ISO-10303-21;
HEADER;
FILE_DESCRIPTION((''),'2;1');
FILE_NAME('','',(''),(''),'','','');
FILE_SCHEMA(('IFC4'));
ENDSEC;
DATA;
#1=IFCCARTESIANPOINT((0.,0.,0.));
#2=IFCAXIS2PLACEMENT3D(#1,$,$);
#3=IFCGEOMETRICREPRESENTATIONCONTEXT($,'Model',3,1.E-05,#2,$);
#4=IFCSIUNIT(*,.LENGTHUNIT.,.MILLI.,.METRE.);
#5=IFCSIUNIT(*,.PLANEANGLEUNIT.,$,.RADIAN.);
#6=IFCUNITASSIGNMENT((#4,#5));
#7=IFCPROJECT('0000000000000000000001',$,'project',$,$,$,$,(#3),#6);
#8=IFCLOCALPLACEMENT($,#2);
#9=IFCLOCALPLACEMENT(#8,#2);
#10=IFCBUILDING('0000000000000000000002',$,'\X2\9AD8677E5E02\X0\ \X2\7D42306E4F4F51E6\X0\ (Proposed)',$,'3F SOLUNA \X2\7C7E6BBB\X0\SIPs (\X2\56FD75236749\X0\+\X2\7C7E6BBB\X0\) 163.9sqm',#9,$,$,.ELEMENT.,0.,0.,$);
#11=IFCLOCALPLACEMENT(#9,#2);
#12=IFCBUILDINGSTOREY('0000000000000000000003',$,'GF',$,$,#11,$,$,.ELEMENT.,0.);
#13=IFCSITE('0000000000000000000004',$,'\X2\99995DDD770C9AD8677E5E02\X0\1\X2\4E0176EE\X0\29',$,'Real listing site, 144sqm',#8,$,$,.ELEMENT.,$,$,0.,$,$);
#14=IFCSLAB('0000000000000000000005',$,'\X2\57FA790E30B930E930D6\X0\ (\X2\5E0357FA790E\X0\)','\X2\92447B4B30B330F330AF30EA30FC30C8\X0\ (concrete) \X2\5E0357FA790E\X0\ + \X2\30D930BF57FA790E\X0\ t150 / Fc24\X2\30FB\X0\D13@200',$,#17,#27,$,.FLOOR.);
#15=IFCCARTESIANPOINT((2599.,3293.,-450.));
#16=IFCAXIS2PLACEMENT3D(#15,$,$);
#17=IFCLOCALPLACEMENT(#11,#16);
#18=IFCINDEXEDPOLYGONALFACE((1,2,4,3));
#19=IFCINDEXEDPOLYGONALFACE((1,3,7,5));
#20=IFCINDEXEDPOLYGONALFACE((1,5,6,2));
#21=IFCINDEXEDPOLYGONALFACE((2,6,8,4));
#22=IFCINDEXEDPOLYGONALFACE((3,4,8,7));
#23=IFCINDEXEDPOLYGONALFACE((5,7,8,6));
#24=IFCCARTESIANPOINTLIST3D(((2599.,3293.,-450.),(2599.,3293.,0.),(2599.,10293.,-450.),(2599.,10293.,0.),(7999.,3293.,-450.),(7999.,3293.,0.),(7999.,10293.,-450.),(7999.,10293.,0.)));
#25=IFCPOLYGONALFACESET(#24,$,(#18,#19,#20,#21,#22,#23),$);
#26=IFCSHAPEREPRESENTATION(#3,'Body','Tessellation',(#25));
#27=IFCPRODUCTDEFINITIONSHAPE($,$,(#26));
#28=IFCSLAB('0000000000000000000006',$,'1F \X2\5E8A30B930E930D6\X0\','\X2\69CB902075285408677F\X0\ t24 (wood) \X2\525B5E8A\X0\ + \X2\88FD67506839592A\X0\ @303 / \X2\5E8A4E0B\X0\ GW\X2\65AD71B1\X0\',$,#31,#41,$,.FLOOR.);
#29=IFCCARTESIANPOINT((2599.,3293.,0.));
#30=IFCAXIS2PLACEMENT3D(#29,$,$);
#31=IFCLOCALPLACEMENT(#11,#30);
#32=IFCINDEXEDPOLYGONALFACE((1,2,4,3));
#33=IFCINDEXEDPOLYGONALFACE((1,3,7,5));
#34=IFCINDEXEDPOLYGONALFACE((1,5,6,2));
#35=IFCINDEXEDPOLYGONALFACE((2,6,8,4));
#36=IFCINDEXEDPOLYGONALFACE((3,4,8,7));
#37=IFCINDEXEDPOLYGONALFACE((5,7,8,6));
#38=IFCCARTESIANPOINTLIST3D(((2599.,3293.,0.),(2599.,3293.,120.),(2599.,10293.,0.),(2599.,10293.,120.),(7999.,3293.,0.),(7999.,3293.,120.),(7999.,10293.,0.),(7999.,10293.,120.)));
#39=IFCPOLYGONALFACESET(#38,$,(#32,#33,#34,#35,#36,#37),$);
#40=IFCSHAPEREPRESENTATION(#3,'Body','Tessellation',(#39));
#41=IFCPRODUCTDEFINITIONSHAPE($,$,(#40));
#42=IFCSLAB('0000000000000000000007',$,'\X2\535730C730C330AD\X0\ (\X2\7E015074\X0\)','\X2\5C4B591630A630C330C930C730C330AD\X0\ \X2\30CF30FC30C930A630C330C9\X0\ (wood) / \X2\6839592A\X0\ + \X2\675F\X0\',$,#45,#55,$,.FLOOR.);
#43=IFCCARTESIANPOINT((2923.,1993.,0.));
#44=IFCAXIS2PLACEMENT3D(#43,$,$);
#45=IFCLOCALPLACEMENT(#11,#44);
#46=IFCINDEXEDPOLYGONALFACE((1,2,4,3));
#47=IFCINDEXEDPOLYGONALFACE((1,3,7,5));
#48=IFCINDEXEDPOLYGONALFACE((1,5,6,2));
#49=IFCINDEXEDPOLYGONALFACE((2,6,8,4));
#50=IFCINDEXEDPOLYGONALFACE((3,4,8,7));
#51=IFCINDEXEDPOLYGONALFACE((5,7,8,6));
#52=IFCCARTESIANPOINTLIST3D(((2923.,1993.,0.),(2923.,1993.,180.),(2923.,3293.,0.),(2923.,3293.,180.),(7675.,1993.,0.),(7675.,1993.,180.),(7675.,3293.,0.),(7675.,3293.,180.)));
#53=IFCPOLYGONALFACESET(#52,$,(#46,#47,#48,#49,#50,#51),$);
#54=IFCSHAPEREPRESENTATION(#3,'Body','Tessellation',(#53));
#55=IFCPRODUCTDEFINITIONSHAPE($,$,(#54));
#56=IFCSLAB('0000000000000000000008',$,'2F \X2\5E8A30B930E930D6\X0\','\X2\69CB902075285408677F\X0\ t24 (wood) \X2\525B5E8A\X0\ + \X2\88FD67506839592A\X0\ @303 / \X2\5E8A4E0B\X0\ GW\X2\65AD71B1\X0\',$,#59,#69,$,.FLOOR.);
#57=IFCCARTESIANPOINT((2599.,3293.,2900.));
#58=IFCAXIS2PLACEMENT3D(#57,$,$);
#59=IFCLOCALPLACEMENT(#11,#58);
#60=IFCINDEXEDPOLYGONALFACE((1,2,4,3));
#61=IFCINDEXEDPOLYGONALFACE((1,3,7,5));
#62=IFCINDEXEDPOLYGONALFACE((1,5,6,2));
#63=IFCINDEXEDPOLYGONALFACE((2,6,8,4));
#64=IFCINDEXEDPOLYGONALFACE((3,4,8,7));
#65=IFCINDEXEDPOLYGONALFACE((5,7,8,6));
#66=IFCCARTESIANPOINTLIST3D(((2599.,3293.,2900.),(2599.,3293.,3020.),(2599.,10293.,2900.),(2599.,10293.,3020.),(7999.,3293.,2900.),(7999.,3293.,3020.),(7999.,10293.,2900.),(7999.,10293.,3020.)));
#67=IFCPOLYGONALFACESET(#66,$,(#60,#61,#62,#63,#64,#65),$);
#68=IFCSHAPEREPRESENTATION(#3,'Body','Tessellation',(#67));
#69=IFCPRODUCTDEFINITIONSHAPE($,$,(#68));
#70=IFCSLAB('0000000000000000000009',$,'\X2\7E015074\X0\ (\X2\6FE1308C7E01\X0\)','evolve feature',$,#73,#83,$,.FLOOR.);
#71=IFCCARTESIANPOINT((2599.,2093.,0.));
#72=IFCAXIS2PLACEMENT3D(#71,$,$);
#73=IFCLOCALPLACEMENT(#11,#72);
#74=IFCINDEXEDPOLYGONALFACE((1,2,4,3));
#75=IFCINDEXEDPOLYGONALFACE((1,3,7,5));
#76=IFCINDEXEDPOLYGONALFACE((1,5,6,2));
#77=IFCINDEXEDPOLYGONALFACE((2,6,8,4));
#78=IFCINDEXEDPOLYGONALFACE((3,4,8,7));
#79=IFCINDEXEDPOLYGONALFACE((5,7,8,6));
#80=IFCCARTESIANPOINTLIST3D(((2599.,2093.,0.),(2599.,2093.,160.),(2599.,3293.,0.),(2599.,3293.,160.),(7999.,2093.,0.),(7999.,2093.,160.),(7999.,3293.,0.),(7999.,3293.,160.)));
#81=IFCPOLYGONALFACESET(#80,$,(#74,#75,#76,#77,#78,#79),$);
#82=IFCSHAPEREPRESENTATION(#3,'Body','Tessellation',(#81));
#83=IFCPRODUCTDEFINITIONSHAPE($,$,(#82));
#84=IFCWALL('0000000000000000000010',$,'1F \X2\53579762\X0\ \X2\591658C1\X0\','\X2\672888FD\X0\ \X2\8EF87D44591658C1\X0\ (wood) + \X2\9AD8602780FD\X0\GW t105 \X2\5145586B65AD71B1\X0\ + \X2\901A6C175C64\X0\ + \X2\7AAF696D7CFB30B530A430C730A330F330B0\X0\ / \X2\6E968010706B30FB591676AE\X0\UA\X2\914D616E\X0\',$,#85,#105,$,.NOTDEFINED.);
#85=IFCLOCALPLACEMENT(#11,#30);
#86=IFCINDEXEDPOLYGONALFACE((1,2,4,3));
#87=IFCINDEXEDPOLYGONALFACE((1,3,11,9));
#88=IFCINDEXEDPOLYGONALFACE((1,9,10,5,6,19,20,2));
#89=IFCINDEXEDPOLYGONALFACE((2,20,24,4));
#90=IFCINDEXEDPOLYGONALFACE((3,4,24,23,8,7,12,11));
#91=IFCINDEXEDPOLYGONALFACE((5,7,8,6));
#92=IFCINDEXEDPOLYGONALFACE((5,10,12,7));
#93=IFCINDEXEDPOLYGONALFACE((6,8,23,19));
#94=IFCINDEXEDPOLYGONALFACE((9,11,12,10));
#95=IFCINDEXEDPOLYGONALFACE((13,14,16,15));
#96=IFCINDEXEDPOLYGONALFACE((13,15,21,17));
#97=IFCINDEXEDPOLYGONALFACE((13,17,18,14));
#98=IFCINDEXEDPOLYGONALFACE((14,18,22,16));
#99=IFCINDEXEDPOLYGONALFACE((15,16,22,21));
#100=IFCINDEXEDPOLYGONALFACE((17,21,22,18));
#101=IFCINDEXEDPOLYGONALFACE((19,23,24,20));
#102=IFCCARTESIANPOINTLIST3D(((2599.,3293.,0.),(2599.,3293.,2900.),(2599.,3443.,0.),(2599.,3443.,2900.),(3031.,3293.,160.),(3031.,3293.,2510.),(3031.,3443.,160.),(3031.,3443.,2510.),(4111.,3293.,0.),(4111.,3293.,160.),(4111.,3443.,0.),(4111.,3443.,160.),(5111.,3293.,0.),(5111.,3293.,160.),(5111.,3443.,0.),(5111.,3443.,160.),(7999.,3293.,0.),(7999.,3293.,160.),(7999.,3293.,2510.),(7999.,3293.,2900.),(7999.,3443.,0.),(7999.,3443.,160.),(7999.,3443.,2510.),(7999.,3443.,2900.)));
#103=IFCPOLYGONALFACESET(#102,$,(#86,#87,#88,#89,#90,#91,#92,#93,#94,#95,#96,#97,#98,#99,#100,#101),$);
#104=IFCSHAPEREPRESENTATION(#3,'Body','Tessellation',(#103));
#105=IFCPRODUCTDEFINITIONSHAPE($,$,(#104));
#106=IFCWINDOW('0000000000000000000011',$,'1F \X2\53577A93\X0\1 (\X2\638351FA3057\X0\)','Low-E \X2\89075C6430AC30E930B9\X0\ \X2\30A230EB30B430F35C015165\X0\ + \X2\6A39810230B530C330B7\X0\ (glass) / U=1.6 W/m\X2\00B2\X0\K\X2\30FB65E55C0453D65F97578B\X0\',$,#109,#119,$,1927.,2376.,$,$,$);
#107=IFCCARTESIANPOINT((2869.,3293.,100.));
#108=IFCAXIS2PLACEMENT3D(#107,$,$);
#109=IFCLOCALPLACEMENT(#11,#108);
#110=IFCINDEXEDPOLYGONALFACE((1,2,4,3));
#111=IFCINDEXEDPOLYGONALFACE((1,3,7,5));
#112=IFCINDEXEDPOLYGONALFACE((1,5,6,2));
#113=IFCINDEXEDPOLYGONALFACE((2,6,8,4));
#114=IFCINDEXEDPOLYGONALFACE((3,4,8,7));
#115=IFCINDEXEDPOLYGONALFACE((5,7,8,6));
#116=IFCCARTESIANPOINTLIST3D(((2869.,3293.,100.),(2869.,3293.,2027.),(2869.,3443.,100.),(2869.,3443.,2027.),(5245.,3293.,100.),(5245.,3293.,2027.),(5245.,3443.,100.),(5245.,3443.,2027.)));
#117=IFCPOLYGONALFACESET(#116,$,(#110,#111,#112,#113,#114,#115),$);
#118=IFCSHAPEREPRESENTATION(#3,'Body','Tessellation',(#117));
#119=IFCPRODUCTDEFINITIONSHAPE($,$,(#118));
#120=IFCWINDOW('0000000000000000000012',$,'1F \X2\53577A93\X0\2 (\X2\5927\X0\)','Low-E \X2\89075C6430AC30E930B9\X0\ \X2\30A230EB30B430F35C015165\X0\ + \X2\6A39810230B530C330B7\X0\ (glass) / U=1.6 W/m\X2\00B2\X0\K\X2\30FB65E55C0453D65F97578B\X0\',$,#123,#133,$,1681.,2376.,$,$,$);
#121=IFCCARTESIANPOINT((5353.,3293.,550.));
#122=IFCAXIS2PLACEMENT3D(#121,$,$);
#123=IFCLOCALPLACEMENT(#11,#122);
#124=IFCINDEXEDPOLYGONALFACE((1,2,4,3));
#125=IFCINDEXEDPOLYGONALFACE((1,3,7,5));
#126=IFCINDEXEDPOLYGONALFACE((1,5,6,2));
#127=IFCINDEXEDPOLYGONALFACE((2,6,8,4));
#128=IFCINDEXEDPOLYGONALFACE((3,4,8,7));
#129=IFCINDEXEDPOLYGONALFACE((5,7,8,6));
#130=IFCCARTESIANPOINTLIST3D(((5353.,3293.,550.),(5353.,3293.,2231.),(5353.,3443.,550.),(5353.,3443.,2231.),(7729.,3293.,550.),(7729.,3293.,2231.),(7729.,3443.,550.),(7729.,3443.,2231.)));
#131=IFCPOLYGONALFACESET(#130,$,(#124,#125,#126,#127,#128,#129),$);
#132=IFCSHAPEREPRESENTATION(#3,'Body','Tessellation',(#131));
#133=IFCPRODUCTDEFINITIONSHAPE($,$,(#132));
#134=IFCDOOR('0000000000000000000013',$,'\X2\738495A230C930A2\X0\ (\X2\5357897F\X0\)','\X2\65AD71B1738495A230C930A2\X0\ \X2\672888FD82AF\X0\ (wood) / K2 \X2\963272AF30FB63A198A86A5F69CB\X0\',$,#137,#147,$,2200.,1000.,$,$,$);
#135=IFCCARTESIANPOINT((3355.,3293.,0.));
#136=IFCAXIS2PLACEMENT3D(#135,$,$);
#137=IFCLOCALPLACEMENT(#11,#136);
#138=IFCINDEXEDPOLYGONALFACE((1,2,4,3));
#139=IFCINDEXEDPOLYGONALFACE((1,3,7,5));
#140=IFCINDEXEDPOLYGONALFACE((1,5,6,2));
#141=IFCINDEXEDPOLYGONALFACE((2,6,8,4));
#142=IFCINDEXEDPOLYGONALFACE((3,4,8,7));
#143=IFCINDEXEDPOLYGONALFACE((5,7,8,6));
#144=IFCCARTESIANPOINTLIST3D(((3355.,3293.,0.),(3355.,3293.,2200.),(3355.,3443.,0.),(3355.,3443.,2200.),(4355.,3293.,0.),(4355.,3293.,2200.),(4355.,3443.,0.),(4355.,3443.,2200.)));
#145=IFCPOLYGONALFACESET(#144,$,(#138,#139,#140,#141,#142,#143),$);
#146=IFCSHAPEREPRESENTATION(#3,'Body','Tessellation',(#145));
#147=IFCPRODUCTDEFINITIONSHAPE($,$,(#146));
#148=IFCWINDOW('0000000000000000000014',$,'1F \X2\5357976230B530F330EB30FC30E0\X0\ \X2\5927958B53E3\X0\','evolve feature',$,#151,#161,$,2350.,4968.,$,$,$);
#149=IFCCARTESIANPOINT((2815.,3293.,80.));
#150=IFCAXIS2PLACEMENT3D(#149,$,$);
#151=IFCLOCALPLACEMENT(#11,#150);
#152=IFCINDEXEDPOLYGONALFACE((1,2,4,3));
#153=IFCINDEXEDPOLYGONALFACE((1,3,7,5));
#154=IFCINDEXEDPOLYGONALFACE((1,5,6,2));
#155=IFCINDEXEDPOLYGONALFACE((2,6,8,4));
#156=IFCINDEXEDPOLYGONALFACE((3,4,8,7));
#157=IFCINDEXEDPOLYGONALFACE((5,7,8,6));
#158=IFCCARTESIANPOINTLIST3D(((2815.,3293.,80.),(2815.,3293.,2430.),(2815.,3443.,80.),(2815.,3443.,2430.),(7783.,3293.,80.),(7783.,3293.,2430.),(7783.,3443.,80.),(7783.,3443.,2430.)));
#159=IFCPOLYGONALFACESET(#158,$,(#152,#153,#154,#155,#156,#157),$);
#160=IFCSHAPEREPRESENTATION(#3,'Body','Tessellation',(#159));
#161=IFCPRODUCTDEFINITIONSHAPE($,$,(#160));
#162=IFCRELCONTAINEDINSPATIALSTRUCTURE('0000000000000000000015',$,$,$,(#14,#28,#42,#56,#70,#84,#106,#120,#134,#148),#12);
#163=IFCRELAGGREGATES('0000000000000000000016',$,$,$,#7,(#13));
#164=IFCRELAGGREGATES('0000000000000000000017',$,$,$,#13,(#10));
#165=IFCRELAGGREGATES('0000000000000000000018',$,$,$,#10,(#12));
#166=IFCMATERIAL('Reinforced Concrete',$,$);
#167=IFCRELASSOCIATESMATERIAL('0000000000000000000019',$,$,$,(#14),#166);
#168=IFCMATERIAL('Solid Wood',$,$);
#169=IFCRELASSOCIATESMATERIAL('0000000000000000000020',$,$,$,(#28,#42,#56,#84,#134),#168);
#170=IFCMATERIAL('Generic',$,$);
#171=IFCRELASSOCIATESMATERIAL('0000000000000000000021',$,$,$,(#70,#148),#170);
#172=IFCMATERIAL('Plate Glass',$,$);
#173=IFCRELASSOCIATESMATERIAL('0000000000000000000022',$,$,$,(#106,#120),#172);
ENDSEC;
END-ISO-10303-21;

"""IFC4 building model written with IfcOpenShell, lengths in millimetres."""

from ifc_helpers import new_model, si_unit, frame, frame_2d, origin, place, context, project, spatial, rectangle, extrude, material, element, fill, save


model = new_model("IFC4")

# Units and contexts
model_context = context("Model", 3, precision=1e-05, world=origin())
ifc_project = project(units=[si_unit("LENGTHUNIT", "METRE", prefix="MILLI"), si_unit("PLANEANGLEUNIT", "RADIAN")], contexts=[model_context])

# Site, building, storey
site_placement = place(None, origin())
site = spatial("IfcSite", under=ifc_project, at=site_placement, Name="香川県高松市1丁目29", ObjectType="Real listing site, 144sqm", CompositionType="ELEMENT", RefElevation=0.0)
building_placement = place(site_placement, origin())
building = spatial("IfcBuilding", under=site, at=building_placement, Name="高松市 終の住処 (Proposed)", ObjectType="3F SOLUNA 籾殻SIPs (国産杉+籾殻) 163.9sqm", CompositionType="ELEMENT", ElevationOfRefHeight=0.0, ElevationOfTerrain=0.0)
storey_placement = place(building_placement, origin())
storey = spatial("IfcBuildingStorey", under=building, at=storey_placement, Name="GF", CompositionType="ELEMENT", Elevation=0.0)

# Slabs
ifc_material_1 = material(Name="Reinforced Concrete")
slab_1_placement = place(storey_placement, frame((2599.0, 3293.0, -450.0)))
element("IfcSlab", 1, at=slab_1_placement, inside=storey, material=ifc_material_1, Name="基礎スラブ (布基礎)", Description="鉄筋コンクリート (concrete) 布基礎 + ベタ基礎 t150 / Fc24・D13@200", PredefinedType="FLOOR", context=model_context, shape_type="SweptSolid", body=[
    extrude(rectangle(XDim=5400.0, YDim=7000.0, at=frame_2d((2700.0, 3500.0))), frame((2599.0, 3293.0, -450.0)), (0.0, 0.0, 1.0), 450.0),
])
ifc_material_2 = material(Name="Solid Wood")
slab_2_placement = place(storey_placement, frame((2599.0, 3293.0, 0.0)))
element("IfcSlab", 2, at=slab_2_placement, inside=storey, material=ifc_material_2, Name="1F 床スラブ", Description="構造用合板 t24 (wood) 剛床 + 製材根太 @303 / 床下 GW断熱", PredefinedType="FLOOR", context=model_context, shape_type="SweptSolid", body=[
    extrude(rectangle(XDim=5400.0, YDim=7000.0, at=frame_2d((2700.0, 3500.0))), frame((2599.0, 3293.0, 0.0)), (0.0, 0.0, 1.0), 120.0),
])
slab_3_placement = place(storey_placement, frame((2923.0, 1993.0, 0.0)))
element("IfcSlab", 3, at=slab_3_placement, inside=storey, material=ifc_material_2, Name="南デッキ (縁側)", Description="屋外ウッドデッキ ハードウッド (wood) / 根太 + 束", PredefinedType="FLOOR", context=model_context, shape_type="SweptSolid", body=[
    extrude(rectangle(XDim=4752.0, YDim=1300.0, at=frame_2d((2376.0, 650.0))), frame((2923.0, 1993.0, 0.0)), (0.0, 0.0, 1.0), 180.0),
])
slab_4_placement = place(storey_placement, frame((2599.0, 3293.0, 2900.0)))
element("IfcSlab", 4, at=slab_4_placement, inside=storey, material=ifc_material_2, Name="2F 床スラブ", Description="構造用合板 t24 (wood) 剛床 + 製材根太 @303 / 床下 GW断熱", PredefinedType="FLOOR", context=model_context, shape_type="SweptSolid", body=[
    extrude(rectangle(XDim=5400.0, YDim=7000.0, at=frame_2d((2700.0, 3500.0))), frame((2599.0, 3293.0, 2900.0)), (0.0, 0.0, 1.0), 120.0),
])
ifc_material_3 = material(Name="Generic")
slab_5_placement = place(storey_placement, frame((2599.0, 2093.0, 0.0)))
element("IfcSlab", 5, at=slab_5_placement, inside=storey, material=ifc_material_3, Name="縁側 (濡れ縁)", Description="evolve feature", PredefinedType="FLOOR", context=model_context, shape_type="SweptSolid", body=[
    extrude(rectangle(XDim=5400.0, YDim=1200.0, at=frame_2d((2700.0, 600.0))), frame((2599.0, 2093.0, 0.0)), (0.0, 0.0, 1.0), 160.0),
])

# Wall, openings, windows, door
wall_1_placement = place(storey_placement, frame((2599.0, 3293.0, 0.0)))
wall_1 = element("IfcWall", 6, at=wall_1_placement, inside=storey, material=ifc_material_2, Name="1F 南面 外壁", Description="木製 軸組外壁 (wood) + 高性能GW t105 充填断熱 + 通気層 + 窯業系サイディング / 準耐火・外皮UA配慮", PredefinedType="NOTDEFINED", context=model_context, shape_type="SweptSolid", body=[
    extrude(rectangle(XDim=5400.0, YDim=150.0, at=frame_2d((2700.0, 75.0))), frame((2599.0, 3293.0, 0.0)), (0.0, 0.0, 1.0), 2900.0),
])
opening_1_placement = place(storey_placement, frame((2869.0, 3293.0, 100.0)))
opening_1 = element("IfcOpeningElement", 7, at=opening_1_placement, cuts=wall_1, PredefinedType="NOTDEFINED", context=model_context, shape_type="SweptSolid", body=[
    extrude(rectangle(XDim=2376.0, YDim=150.0, at=frame_2d((1188.0, 75.0))), frame((2869.0, 3293.0, 100.0)), (0.0, 0.0, 1.0), 1927.0),
])
opening_2_placement = place(storey_placement, frame((5353.0, 3293.0, 550.0)))
opening_2 = element("IfcOpeningElement", 8, at=opening_2_placement, cuts=wall_1, PredefinedType="NOTDEFINED", context=model_context, shape_type="SweptSolid", body=[
    extrude(rectangle(XDim=2376.0, YDim=150.0, at=frame_2d((1188.0, 75.0))), frame((5353.0, 3293.0, 550.0)), (0.0, 0.0, 1.0), 1681.0),
])
opening_3_placement = place(storey_placement, frame((3355.0, 3293.0, 0.0)))
opening_3 = element("IfcOpeningElement", 9, at=opening_3_placement, cuts=wall_1, PredefinedType="NOTDEFINED", context=model_context, shape_type="SweptSolid", body=[
    extrude(rectangle(XDim=1000.0, YDim=150.0, at=frame_2d((500.0, 75.0))), frame((3355.0, 3293.0, 0.0)), (0.0, 0.0, 1.0), 2200.0),
])
opening_4_placement = place(storey_placement, frame((2815.0, 3293.0, 80.0)))
opening_4 = element("IfcOpeningElement", 10, at=opening_4_placement, cuts=wall_1, PredefinedType="NOTDEFINED", context=model_context, shape_type="SweptSolid", body=[
    extrude(rectangle(XDim=4968.0, YDim=150.0, at=frame_2d((2484.0, 75.0))), frame((2815.0, 3293.0, 80.0)), (0.0, 0.0, 1.0), 2350.0),
])
ifc_material_4 = material(Name="Plate Glass")
window_1_placement = place(storey_placement, frame((2869.0, 3293.0, 100.0)))
window_1 = element("IfcWindow", 11, at=window_1_placement, inside=storey, material=ifc_material_4, Name="1F 南窓1 (掃出し)", Description="Low-E 複層ガラス アルゴン封入 + 樹脂サッシ (glass) / U=1.6 W/m²K・日射取得型", OverallHeight=1927.0, OverallWidth=2376.0, context=model_context, shape_type="SweptSolid", body=[
    extrude(rectangle(XDim=2376.0, YDim=150.0, at=frame_2d((1188.0, 75.0))), frame((2869.0, 3293.0, 100.0)), (0.0, 0.0, 1.0), 1927.0),
])
fill(opening_1, window_1)
window_2_placement = place(storey_placement, frame((5353.0, 3293.0, 550.0)))
window_2 = element("IfcWindow", 12, at=window_2_placement, inside=storey, material=ifc_material_4, Name="1F 南窓2 (大)", Description="Low-E 複層ガラス アルゴン封入 + 樹脂サッシ (glass) / U=1.6 W/m²K・日射取得型", OverallHeight=1681.0, OverallWidth=2376.0, context=model_context, shape_type="SweptSolid", body=[
    extrude(rectangle(XDim=2376.0, YDim=150.0, at=frame_2d((1188.0, 75.0))), frame((5353.0, 3293.0, 550.0)), (0.0, 0.0, 1.0), 1681.0),
])
fill(opening_2, window_2)
door_placement = place(storey_placement, frame((3355.0, 3293.0, 0.0)))
door = element("IfcDoor", 13, at=door_placement, inside=storey, material=ifc_material_2, Name="玄関ドア (南西)", Description="断熱玄関ドア 木製芯 (wood) / K2 防犯・採風機構", OverallHeight=2200.0, OverallWidth=1000.0, context=model_context, shape_type="SweptSolid", body=[
    extrude(rectangle(XDim=1000.0, YDim=150.0, at=frame_2d((500.0, 75.0))), frame((3355.0, 3293.0, 0.0)), (0.0, 0.0, 1.0), 2200.0),
])
fill(opening_3, door)
window_3_placement = place(storey_placement, frame((2815.0, 3293.0, 80.0)))
window_3 = element("IfcWindow", 14, at=window_3_placement, inside=storey, material=ifc_material_3, Name="1F 南面サンルーム 大開口", Description="evolve feature", OverallHeight=2350.0, OverallWidth=4968.0, context=model_context, shape_type="SweptSolid", body=[
    extrude(rectangle(XDim=4968.0, YDim=150.0, at=frame_2d((2484.0, 75.0))), frame((2815.0, 3293.0, 80.0)), (0.0, 0.0, 1.0), 2350.0),
])
fill(opening_4, window_3)

save(model, "model.ifc")
